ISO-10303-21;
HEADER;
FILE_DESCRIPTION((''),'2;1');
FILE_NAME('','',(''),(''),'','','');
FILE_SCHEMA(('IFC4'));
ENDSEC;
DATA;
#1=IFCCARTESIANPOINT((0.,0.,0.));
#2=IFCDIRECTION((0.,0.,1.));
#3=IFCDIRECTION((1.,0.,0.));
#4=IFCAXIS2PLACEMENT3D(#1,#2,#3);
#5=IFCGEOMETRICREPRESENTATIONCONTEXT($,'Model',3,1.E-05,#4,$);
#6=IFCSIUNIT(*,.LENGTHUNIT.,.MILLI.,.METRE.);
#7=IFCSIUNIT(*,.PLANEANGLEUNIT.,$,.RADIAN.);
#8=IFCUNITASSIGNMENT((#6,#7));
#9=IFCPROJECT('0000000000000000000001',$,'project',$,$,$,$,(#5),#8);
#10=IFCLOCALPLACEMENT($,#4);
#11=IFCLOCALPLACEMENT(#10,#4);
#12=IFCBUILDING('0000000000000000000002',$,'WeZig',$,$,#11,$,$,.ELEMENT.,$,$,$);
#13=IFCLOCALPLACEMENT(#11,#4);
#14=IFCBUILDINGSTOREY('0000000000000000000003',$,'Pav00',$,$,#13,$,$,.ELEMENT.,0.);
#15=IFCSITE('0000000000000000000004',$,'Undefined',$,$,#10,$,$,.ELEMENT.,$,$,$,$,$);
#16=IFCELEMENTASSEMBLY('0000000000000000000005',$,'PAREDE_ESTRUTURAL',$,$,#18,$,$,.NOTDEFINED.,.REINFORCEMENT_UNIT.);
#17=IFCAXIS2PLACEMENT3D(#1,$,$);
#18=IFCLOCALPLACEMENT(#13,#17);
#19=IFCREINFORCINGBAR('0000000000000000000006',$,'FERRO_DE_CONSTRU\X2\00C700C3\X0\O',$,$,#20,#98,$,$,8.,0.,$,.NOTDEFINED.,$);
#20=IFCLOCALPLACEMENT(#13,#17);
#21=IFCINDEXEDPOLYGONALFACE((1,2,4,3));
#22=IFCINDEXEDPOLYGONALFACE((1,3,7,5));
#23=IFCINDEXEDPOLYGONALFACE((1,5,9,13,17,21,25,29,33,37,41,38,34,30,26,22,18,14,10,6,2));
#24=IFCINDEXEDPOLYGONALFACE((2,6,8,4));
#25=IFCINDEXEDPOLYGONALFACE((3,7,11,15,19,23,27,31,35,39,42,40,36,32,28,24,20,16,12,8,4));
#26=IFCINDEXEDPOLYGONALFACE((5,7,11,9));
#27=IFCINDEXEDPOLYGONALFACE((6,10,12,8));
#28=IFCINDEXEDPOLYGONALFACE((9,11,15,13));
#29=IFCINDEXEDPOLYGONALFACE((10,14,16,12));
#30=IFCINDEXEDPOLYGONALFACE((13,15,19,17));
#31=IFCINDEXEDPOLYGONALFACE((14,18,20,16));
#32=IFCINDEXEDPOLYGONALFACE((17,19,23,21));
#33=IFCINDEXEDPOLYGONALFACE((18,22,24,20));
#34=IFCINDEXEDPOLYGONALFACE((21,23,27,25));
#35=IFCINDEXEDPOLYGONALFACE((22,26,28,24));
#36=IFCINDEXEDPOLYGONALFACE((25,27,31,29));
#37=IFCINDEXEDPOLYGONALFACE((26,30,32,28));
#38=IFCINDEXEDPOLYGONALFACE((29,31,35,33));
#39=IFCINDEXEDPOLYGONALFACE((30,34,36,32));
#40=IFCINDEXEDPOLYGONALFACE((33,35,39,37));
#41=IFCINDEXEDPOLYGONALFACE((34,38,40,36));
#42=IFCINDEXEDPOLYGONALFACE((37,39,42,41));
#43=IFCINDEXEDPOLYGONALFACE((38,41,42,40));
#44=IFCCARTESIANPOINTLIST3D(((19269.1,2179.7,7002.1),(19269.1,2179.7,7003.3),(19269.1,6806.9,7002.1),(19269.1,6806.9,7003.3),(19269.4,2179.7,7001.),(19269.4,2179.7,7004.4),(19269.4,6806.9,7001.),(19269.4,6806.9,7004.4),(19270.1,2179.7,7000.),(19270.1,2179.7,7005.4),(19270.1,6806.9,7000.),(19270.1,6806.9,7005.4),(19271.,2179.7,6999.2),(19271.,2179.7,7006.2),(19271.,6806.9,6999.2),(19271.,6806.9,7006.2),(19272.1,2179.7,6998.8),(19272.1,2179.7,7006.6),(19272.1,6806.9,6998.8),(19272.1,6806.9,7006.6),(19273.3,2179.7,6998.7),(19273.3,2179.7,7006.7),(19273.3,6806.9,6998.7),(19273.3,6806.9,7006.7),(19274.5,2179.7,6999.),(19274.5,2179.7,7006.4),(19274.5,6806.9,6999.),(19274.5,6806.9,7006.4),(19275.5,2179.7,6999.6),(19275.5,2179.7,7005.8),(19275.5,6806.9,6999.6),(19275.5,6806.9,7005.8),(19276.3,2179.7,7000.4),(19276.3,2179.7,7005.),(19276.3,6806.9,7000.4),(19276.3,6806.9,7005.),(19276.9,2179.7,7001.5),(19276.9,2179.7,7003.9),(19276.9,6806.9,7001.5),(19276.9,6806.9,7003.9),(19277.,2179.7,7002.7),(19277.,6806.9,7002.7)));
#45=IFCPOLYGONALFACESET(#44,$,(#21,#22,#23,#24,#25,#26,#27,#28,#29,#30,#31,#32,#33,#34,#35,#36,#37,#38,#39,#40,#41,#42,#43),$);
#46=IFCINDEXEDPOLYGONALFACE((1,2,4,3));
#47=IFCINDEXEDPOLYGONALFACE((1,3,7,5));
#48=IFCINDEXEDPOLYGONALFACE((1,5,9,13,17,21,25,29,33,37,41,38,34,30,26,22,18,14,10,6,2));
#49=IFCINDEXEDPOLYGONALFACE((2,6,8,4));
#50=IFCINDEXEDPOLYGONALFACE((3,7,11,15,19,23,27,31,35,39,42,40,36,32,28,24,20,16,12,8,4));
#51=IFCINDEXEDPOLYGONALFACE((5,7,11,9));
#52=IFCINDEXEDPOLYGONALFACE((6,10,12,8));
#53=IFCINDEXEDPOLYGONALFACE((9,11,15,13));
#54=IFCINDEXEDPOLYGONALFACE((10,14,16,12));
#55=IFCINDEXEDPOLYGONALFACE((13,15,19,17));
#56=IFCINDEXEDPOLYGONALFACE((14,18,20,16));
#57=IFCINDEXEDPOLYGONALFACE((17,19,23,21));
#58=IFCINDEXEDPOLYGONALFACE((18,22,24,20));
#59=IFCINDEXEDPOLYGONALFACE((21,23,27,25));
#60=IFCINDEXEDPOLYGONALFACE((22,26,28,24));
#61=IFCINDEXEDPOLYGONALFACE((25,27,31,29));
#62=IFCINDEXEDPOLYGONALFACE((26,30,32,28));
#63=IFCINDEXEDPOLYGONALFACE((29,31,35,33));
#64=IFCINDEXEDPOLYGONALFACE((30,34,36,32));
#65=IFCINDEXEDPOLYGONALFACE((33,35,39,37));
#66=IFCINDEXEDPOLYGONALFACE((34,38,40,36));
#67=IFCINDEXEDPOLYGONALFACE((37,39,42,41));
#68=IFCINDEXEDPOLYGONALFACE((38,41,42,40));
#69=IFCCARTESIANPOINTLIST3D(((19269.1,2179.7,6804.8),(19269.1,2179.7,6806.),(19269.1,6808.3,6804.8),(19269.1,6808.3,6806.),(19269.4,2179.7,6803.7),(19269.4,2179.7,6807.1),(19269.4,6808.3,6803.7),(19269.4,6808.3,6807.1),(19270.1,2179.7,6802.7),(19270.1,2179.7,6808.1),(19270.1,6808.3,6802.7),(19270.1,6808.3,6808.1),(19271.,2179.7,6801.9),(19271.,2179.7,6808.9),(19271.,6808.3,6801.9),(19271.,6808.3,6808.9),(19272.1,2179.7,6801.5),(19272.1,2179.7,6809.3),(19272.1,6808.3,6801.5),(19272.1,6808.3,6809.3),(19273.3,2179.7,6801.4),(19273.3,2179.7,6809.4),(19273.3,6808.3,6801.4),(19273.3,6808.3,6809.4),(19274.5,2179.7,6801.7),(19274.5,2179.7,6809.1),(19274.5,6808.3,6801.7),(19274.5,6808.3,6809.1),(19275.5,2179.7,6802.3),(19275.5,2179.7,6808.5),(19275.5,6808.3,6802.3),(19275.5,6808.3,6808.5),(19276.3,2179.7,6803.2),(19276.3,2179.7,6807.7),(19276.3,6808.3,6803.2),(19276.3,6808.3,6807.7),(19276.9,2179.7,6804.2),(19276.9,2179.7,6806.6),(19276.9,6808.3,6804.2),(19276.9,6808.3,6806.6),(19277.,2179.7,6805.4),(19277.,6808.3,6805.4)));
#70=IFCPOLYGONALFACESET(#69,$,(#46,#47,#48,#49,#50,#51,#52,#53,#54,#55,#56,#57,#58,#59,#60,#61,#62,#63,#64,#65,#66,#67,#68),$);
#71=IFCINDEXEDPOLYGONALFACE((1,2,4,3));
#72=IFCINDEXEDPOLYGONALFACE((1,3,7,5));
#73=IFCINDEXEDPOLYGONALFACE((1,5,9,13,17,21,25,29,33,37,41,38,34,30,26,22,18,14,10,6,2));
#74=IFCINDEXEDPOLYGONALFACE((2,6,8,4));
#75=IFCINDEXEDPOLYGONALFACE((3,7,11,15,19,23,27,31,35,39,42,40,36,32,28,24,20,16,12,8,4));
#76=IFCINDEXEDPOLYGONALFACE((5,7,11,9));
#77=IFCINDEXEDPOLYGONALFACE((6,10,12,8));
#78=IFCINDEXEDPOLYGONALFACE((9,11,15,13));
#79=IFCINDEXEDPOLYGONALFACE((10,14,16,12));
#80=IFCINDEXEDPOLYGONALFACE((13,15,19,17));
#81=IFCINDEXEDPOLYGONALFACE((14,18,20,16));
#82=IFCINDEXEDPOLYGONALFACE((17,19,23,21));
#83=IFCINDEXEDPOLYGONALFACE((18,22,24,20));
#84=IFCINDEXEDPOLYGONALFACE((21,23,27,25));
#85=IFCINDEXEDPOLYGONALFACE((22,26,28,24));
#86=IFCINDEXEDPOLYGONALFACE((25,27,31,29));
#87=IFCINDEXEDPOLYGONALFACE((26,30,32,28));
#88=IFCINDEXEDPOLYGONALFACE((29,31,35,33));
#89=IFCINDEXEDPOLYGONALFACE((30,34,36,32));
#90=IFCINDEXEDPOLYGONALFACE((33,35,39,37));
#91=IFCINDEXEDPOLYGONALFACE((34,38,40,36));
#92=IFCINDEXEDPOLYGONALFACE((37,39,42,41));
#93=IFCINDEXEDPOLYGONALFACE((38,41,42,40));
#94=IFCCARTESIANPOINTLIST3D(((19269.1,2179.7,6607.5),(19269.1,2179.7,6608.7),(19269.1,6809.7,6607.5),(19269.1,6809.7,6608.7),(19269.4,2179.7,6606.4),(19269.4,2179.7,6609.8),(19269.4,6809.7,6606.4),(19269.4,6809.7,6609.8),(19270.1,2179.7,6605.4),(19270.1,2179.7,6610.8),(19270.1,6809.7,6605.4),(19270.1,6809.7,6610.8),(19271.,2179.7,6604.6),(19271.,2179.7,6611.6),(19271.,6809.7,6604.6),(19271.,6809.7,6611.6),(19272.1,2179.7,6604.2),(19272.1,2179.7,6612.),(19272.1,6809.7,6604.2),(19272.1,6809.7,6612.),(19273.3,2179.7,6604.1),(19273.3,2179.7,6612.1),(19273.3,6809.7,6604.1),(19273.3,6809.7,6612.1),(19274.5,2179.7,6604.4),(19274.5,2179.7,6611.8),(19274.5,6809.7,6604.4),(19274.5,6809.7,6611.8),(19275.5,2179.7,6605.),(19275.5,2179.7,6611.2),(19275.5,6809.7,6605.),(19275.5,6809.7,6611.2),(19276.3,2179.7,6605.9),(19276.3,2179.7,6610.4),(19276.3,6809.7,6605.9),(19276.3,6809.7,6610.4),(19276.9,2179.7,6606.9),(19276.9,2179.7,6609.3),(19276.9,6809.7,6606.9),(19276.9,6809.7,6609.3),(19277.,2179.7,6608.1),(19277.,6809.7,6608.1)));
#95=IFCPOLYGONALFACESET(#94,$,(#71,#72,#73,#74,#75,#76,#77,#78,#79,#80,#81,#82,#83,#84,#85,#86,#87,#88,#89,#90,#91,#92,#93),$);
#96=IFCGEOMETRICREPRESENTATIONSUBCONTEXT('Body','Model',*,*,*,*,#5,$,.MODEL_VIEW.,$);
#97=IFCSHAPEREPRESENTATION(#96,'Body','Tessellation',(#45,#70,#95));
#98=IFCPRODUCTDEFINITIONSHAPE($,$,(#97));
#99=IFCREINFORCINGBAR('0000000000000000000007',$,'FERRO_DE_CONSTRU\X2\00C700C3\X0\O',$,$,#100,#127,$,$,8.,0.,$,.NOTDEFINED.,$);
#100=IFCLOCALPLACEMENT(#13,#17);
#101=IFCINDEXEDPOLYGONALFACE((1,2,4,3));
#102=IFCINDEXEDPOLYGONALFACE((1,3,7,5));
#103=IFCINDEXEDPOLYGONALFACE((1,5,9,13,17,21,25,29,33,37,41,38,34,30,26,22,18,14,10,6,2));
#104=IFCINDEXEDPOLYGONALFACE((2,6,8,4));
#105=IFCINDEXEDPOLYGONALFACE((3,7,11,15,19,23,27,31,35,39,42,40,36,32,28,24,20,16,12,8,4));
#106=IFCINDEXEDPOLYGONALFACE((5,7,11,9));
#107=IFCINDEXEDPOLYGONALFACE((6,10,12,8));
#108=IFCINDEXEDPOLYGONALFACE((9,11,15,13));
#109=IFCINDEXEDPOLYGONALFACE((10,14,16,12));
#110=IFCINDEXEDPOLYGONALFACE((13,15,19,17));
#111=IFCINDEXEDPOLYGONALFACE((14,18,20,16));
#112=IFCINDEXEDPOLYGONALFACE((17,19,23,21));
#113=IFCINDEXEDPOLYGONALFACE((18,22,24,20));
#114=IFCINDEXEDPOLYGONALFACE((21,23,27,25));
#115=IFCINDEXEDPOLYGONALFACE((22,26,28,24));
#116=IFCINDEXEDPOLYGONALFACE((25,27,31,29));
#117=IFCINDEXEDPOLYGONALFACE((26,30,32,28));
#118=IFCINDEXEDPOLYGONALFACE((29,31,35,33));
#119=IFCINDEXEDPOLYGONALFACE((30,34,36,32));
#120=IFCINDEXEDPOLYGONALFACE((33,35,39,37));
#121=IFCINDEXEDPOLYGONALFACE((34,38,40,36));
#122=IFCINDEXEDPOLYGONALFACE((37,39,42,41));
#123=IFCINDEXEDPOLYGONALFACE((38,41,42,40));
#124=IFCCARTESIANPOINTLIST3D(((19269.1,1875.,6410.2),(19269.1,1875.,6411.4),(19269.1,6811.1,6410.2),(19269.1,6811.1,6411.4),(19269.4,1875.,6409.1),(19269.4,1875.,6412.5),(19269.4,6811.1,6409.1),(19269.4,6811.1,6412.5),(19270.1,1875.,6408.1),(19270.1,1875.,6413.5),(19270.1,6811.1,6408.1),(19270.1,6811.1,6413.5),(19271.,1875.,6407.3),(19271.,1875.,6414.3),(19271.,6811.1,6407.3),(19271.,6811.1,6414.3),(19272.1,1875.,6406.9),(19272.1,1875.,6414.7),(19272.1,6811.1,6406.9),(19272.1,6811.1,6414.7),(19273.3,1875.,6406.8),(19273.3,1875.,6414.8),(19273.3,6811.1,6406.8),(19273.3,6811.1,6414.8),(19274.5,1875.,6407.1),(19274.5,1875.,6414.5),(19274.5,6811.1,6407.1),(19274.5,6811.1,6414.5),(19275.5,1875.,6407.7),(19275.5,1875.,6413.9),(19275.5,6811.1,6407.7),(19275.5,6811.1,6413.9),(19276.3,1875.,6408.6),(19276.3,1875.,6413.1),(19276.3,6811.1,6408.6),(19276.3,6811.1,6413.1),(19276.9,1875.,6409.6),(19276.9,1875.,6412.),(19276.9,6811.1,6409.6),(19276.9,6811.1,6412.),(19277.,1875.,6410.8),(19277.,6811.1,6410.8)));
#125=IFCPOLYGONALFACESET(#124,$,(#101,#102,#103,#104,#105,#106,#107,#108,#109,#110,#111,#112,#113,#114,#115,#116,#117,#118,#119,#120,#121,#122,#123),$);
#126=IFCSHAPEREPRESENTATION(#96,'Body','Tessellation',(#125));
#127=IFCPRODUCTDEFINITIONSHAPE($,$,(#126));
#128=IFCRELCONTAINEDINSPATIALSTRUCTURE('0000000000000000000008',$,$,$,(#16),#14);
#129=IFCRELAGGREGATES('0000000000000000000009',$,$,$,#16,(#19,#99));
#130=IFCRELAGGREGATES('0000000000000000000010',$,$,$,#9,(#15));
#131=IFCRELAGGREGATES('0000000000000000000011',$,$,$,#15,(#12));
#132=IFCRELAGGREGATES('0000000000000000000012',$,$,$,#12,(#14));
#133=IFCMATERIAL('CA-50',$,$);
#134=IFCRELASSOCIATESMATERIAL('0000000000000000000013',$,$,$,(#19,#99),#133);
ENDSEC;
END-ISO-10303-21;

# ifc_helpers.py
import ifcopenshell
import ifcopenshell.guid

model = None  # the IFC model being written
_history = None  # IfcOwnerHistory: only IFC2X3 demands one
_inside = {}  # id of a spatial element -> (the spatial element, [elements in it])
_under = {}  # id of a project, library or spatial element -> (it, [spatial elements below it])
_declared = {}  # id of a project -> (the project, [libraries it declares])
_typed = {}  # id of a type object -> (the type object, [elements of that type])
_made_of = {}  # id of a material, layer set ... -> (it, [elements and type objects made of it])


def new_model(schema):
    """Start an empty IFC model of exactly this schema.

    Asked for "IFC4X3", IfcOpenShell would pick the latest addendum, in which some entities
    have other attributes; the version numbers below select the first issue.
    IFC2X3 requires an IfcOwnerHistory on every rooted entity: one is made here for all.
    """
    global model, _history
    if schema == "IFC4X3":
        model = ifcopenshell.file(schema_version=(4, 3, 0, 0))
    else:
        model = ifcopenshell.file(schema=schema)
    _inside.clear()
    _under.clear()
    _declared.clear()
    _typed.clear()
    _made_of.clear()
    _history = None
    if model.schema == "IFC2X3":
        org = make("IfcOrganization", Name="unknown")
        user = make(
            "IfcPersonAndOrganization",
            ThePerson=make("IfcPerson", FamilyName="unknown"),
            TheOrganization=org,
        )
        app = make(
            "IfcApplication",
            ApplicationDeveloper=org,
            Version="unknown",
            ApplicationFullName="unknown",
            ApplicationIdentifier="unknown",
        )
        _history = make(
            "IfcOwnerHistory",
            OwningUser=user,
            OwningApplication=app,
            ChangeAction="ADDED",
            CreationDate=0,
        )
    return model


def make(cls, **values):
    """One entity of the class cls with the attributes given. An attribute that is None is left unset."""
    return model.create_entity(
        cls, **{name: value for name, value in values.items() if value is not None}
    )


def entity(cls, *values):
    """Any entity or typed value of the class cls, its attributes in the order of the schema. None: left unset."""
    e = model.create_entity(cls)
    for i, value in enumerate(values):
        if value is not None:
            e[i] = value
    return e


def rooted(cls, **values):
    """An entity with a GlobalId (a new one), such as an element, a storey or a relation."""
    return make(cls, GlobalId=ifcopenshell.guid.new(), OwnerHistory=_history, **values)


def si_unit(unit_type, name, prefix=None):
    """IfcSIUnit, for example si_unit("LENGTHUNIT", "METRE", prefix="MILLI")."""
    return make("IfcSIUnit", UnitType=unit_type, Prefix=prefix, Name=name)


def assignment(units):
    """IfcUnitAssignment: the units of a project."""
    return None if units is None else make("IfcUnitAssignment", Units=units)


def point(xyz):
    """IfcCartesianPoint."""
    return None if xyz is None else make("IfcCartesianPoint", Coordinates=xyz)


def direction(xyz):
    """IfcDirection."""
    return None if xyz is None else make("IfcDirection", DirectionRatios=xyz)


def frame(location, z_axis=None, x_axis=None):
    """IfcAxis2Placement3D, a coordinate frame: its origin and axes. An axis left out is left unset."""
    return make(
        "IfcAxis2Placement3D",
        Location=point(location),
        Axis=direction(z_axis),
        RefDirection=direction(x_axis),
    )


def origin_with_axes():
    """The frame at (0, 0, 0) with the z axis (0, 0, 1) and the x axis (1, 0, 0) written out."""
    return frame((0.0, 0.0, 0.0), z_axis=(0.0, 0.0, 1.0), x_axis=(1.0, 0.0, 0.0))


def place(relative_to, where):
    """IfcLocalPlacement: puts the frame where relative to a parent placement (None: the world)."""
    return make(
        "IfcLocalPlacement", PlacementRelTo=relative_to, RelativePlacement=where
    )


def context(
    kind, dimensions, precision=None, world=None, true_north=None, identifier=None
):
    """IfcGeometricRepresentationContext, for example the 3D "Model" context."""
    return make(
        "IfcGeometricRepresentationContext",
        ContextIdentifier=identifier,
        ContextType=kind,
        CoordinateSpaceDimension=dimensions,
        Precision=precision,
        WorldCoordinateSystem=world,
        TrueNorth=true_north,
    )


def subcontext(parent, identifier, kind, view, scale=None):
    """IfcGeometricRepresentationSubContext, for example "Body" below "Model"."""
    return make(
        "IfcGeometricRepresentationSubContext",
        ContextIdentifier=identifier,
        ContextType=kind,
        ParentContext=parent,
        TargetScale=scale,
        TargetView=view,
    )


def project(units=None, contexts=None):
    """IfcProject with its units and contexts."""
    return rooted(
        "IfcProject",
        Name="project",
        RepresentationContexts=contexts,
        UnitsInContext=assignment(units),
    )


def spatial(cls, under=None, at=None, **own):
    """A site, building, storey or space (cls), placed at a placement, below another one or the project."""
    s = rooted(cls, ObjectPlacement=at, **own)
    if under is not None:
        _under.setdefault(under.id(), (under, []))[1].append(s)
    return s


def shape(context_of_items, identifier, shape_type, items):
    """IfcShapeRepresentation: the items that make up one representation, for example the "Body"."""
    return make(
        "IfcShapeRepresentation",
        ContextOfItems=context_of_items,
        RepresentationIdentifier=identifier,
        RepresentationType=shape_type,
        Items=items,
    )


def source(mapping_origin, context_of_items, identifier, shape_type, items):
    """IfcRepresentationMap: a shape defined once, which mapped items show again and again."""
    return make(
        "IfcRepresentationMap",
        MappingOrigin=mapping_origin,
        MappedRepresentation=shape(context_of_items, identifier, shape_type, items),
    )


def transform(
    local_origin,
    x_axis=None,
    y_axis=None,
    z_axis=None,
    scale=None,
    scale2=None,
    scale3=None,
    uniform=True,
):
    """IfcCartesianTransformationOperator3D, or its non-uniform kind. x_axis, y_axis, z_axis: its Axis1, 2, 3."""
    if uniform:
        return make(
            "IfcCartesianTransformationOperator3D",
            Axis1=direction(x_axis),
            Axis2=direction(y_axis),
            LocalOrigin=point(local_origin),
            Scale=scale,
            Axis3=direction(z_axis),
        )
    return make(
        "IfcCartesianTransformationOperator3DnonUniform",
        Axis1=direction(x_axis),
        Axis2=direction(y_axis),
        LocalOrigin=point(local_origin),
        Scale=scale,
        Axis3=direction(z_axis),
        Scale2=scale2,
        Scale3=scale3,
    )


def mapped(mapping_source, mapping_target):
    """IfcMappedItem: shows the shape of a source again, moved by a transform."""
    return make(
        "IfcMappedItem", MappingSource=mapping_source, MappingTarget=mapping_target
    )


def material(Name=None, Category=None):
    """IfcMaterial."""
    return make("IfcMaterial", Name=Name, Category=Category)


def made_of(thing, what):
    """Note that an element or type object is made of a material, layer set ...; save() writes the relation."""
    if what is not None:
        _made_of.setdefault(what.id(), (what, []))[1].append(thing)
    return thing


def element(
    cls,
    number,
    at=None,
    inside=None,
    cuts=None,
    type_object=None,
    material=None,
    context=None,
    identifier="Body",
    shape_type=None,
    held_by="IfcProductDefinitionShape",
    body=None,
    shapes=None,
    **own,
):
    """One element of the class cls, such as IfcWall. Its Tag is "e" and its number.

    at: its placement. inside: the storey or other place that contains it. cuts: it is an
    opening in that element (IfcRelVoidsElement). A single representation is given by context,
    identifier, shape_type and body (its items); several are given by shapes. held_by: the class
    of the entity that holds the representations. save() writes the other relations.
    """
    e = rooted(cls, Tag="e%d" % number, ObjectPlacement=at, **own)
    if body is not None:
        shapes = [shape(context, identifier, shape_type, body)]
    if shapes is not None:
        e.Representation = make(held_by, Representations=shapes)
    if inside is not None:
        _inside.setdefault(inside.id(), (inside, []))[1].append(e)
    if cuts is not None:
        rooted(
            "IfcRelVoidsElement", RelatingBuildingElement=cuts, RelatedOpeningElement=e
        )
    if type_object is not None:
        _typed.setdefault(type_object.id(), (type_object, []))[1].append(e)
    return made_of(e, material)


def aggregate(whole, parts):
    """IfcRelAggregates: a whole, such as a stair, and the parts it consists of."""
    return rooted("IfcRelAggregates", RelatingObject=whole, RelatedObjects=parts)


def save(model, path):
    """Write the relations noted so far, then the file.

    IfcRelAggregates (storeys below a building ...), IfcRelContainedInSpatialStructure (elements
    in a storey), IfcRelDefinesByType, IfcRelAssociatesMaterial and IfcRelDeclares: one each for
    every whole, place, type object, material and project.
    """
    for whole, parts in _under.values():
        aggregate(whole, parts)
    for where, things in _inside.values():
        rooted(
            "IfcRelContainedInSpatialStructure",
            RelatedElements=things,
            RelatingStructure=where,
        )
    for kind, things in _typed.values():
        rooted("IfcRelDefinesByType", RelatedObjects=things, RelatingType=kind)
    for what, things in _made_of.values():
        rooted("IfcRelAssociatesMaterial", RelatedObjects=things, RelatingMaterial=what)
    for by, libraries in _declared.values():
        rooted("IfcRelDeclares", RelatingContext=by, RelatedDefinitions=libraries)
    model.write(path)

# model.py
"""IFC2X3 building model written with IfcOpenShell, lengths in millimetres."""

from ifc_helpers import new_model, entity, si_unit, frame, origin_with_axes, place, context, subcontext, project, spatial, source, transform, mapped, material, element, aggregate, save


model = new_model("IFC2X3")

# Units and contexts
model_context = context("Model", 3, precision=1e-05, world=origin_with_axes())
body_context = subcontext(model_context, "Body", "Model", "MODEL_VIEW")
ifc_project = project(units=[si_unit("LENGTHUNIT", "METRE", prefix="MILLI"), si_unit("PLANEANGLEUNIT", "RADIAN")], contexts=[model_context])

# Site, building, storey
site_placement = place(None, origin_with_axes())
site = spatial("IfcSite", under=ifc_project, at=site_placement, Name="Undefined", CompositionType="ELEMENT")
building_placement = place(site_placement, origin_with_axes())
building = spatial("IfcBuilding", under=site, at=building_placement, Name="WeZig", CompositionType="ELEMENT")
storey_placement = place(building_placement, origin_with_axes())
storey = spatial("IfcBuildingStorey", under=building, at=storey_placement, Name="Pav00", CompositionType="ELEMENT", Elevation=0.0)

# Shared definitions
ifc_material_1 = material(Name="CA-50")

# Element assembly, reinforcing bars
assembly_1_placement = place(storey_placement, origin_with_axes())
assembly_1 = element("IfcElementAssembly", 1, at=assembly_1_placement, inside=storey, Name="PAREDE_ESTRUTURAL", AssemblyPlace="NOTDEFINED", PredefinedType="REINFORCEMENT_UNIT")
shared_shape_1 = source(origin_with_axes(), body_context, "Body", "AdvancedSweptSolid", [
    entity("IfcSweptDiskSolid", entity("IfcTrimmedCurve", entity("IfcLine", entity("IfcCartesianPoint", [0.0, 0.0, 0.0]), entity("IfcVector", entity("IfcDirection", [1.0, 0.0, 0.0]), 1.0)), [entity("IfcParameterValue", 0.0)], [entity("IfcParameterValue", 4627.181999)], True, "PARAMETER"), 4.0, None, 0.0, 4627.2),
])
shared_shape_2 = source(origin_with_axes(), body_context, "Body", "AdvancedSweptSolid", [
    entity("IfcSweptDiskSolid", entity("IfcTrimmedCurve", entity("IfcLine", entity("IfcCartesianPoint", [0.0, 0.0, 0.0]), entity("IfcVector", entity("IfcDirection", [1.0, 0.0, 0.0]), 1.0)), [entity("IfcParameterValue", 0.0)], [entity("IfcParameterValue", 4628.595646)], True, "PARAMETER"), 4.0, None, 0.0, 4628.6),
])
shared_shape_3 = source(origin_with_axes(), body_context, "Body", "AdvancedSweptSolid", [
    entity("IfcSweptDiskSolid", entity("IfcTrimmedCurve", entity("IfcLine", entity("IfcCartesianPoint", [0.0, 0.0, 0.0]), entity("IfcVector", entity("IfcDirection", [1.0, 0.0, 0.0]), 1.0)), [entity("IfcParameterValue", 0.0)], [entity("IfcParameterValue", 4630.009294)], True, "PARAMETER"), 4.0, None, 0.0, 4630.0),
])
reinforcing_bar_1_placement = place(assembly_1_placement, frame((19273.0, 6806.9, 7002.7), z_axis=(1.0, 0.0, 0.0), x_axis=(0.0, -1.0, 0.0)))
reinforcing_bar_1 = element("IfcReinforcingBar", 2, at=reinforcing_bar_1_placement, material=ifc_material_1, Name="FERRO_DE_CONSTRUÇÃO", BarRole="NOTDEFINED", CrossSectionArea=0.0, NominalDiameter=8.0, context=body_context, shape_type="MappedRepresentation", body=[
    mapped(shared_shape_1, transform((0.0, 0.0, 0.0))),
    mapped(shared_shape_2, transform((-1.4, 197.3, 0.0))),
    mapped(shared_shape_3, transform((-2.8, 394.6, 0.0))),
])
shared_shape_4 = source(origin_with_axes(), body_context, "Body", "AdvancedSweptSolid", [
    entity("IfcSweptDiskSolid", entity("IfcTrimmedCurve", entity("IfcLine", entity("IfcCartesianPoint", [0.0, 0.0, 0.0]), entity("IfcVector", entity("IfcDirection", [1.0, 0.0, 0.0]), 1.0)), [entity("IfcParameterValue", 0.0)], [entity("IfcParameterValue", 4936.099941)], True, "PARAMETER"), 4.0, None, 0.0, 4936.1),
])
reinforcing_bar_2_placement = place(assembly_1_placement, frame((19273.0, 6811.1, 6410.8), z_axis=(1.0, 0.0, 0.0), x_axis=(0.0, -1.0, 0.0)))
reinforcing_bar_2 = element("IfcReinforcingBar", 3, at=reinforcing_bar_2_placement, material=ifc_material_1, Name="FERRO_DE_CONSTRUÇÃO", BarRole="NOTDEFINED", CrossSectionArea=0.0, NominalDiameter=8.0, context=body_context, shape_type="MappedRepresentation", body=[
    mapped(shared_shape_4, transform((0.0, 0.0, 0.0))),
])
aggregate(assembly_1, [reinforcing_bar_1, reinforcing_bar_2])

save(model, "model.ifc")
